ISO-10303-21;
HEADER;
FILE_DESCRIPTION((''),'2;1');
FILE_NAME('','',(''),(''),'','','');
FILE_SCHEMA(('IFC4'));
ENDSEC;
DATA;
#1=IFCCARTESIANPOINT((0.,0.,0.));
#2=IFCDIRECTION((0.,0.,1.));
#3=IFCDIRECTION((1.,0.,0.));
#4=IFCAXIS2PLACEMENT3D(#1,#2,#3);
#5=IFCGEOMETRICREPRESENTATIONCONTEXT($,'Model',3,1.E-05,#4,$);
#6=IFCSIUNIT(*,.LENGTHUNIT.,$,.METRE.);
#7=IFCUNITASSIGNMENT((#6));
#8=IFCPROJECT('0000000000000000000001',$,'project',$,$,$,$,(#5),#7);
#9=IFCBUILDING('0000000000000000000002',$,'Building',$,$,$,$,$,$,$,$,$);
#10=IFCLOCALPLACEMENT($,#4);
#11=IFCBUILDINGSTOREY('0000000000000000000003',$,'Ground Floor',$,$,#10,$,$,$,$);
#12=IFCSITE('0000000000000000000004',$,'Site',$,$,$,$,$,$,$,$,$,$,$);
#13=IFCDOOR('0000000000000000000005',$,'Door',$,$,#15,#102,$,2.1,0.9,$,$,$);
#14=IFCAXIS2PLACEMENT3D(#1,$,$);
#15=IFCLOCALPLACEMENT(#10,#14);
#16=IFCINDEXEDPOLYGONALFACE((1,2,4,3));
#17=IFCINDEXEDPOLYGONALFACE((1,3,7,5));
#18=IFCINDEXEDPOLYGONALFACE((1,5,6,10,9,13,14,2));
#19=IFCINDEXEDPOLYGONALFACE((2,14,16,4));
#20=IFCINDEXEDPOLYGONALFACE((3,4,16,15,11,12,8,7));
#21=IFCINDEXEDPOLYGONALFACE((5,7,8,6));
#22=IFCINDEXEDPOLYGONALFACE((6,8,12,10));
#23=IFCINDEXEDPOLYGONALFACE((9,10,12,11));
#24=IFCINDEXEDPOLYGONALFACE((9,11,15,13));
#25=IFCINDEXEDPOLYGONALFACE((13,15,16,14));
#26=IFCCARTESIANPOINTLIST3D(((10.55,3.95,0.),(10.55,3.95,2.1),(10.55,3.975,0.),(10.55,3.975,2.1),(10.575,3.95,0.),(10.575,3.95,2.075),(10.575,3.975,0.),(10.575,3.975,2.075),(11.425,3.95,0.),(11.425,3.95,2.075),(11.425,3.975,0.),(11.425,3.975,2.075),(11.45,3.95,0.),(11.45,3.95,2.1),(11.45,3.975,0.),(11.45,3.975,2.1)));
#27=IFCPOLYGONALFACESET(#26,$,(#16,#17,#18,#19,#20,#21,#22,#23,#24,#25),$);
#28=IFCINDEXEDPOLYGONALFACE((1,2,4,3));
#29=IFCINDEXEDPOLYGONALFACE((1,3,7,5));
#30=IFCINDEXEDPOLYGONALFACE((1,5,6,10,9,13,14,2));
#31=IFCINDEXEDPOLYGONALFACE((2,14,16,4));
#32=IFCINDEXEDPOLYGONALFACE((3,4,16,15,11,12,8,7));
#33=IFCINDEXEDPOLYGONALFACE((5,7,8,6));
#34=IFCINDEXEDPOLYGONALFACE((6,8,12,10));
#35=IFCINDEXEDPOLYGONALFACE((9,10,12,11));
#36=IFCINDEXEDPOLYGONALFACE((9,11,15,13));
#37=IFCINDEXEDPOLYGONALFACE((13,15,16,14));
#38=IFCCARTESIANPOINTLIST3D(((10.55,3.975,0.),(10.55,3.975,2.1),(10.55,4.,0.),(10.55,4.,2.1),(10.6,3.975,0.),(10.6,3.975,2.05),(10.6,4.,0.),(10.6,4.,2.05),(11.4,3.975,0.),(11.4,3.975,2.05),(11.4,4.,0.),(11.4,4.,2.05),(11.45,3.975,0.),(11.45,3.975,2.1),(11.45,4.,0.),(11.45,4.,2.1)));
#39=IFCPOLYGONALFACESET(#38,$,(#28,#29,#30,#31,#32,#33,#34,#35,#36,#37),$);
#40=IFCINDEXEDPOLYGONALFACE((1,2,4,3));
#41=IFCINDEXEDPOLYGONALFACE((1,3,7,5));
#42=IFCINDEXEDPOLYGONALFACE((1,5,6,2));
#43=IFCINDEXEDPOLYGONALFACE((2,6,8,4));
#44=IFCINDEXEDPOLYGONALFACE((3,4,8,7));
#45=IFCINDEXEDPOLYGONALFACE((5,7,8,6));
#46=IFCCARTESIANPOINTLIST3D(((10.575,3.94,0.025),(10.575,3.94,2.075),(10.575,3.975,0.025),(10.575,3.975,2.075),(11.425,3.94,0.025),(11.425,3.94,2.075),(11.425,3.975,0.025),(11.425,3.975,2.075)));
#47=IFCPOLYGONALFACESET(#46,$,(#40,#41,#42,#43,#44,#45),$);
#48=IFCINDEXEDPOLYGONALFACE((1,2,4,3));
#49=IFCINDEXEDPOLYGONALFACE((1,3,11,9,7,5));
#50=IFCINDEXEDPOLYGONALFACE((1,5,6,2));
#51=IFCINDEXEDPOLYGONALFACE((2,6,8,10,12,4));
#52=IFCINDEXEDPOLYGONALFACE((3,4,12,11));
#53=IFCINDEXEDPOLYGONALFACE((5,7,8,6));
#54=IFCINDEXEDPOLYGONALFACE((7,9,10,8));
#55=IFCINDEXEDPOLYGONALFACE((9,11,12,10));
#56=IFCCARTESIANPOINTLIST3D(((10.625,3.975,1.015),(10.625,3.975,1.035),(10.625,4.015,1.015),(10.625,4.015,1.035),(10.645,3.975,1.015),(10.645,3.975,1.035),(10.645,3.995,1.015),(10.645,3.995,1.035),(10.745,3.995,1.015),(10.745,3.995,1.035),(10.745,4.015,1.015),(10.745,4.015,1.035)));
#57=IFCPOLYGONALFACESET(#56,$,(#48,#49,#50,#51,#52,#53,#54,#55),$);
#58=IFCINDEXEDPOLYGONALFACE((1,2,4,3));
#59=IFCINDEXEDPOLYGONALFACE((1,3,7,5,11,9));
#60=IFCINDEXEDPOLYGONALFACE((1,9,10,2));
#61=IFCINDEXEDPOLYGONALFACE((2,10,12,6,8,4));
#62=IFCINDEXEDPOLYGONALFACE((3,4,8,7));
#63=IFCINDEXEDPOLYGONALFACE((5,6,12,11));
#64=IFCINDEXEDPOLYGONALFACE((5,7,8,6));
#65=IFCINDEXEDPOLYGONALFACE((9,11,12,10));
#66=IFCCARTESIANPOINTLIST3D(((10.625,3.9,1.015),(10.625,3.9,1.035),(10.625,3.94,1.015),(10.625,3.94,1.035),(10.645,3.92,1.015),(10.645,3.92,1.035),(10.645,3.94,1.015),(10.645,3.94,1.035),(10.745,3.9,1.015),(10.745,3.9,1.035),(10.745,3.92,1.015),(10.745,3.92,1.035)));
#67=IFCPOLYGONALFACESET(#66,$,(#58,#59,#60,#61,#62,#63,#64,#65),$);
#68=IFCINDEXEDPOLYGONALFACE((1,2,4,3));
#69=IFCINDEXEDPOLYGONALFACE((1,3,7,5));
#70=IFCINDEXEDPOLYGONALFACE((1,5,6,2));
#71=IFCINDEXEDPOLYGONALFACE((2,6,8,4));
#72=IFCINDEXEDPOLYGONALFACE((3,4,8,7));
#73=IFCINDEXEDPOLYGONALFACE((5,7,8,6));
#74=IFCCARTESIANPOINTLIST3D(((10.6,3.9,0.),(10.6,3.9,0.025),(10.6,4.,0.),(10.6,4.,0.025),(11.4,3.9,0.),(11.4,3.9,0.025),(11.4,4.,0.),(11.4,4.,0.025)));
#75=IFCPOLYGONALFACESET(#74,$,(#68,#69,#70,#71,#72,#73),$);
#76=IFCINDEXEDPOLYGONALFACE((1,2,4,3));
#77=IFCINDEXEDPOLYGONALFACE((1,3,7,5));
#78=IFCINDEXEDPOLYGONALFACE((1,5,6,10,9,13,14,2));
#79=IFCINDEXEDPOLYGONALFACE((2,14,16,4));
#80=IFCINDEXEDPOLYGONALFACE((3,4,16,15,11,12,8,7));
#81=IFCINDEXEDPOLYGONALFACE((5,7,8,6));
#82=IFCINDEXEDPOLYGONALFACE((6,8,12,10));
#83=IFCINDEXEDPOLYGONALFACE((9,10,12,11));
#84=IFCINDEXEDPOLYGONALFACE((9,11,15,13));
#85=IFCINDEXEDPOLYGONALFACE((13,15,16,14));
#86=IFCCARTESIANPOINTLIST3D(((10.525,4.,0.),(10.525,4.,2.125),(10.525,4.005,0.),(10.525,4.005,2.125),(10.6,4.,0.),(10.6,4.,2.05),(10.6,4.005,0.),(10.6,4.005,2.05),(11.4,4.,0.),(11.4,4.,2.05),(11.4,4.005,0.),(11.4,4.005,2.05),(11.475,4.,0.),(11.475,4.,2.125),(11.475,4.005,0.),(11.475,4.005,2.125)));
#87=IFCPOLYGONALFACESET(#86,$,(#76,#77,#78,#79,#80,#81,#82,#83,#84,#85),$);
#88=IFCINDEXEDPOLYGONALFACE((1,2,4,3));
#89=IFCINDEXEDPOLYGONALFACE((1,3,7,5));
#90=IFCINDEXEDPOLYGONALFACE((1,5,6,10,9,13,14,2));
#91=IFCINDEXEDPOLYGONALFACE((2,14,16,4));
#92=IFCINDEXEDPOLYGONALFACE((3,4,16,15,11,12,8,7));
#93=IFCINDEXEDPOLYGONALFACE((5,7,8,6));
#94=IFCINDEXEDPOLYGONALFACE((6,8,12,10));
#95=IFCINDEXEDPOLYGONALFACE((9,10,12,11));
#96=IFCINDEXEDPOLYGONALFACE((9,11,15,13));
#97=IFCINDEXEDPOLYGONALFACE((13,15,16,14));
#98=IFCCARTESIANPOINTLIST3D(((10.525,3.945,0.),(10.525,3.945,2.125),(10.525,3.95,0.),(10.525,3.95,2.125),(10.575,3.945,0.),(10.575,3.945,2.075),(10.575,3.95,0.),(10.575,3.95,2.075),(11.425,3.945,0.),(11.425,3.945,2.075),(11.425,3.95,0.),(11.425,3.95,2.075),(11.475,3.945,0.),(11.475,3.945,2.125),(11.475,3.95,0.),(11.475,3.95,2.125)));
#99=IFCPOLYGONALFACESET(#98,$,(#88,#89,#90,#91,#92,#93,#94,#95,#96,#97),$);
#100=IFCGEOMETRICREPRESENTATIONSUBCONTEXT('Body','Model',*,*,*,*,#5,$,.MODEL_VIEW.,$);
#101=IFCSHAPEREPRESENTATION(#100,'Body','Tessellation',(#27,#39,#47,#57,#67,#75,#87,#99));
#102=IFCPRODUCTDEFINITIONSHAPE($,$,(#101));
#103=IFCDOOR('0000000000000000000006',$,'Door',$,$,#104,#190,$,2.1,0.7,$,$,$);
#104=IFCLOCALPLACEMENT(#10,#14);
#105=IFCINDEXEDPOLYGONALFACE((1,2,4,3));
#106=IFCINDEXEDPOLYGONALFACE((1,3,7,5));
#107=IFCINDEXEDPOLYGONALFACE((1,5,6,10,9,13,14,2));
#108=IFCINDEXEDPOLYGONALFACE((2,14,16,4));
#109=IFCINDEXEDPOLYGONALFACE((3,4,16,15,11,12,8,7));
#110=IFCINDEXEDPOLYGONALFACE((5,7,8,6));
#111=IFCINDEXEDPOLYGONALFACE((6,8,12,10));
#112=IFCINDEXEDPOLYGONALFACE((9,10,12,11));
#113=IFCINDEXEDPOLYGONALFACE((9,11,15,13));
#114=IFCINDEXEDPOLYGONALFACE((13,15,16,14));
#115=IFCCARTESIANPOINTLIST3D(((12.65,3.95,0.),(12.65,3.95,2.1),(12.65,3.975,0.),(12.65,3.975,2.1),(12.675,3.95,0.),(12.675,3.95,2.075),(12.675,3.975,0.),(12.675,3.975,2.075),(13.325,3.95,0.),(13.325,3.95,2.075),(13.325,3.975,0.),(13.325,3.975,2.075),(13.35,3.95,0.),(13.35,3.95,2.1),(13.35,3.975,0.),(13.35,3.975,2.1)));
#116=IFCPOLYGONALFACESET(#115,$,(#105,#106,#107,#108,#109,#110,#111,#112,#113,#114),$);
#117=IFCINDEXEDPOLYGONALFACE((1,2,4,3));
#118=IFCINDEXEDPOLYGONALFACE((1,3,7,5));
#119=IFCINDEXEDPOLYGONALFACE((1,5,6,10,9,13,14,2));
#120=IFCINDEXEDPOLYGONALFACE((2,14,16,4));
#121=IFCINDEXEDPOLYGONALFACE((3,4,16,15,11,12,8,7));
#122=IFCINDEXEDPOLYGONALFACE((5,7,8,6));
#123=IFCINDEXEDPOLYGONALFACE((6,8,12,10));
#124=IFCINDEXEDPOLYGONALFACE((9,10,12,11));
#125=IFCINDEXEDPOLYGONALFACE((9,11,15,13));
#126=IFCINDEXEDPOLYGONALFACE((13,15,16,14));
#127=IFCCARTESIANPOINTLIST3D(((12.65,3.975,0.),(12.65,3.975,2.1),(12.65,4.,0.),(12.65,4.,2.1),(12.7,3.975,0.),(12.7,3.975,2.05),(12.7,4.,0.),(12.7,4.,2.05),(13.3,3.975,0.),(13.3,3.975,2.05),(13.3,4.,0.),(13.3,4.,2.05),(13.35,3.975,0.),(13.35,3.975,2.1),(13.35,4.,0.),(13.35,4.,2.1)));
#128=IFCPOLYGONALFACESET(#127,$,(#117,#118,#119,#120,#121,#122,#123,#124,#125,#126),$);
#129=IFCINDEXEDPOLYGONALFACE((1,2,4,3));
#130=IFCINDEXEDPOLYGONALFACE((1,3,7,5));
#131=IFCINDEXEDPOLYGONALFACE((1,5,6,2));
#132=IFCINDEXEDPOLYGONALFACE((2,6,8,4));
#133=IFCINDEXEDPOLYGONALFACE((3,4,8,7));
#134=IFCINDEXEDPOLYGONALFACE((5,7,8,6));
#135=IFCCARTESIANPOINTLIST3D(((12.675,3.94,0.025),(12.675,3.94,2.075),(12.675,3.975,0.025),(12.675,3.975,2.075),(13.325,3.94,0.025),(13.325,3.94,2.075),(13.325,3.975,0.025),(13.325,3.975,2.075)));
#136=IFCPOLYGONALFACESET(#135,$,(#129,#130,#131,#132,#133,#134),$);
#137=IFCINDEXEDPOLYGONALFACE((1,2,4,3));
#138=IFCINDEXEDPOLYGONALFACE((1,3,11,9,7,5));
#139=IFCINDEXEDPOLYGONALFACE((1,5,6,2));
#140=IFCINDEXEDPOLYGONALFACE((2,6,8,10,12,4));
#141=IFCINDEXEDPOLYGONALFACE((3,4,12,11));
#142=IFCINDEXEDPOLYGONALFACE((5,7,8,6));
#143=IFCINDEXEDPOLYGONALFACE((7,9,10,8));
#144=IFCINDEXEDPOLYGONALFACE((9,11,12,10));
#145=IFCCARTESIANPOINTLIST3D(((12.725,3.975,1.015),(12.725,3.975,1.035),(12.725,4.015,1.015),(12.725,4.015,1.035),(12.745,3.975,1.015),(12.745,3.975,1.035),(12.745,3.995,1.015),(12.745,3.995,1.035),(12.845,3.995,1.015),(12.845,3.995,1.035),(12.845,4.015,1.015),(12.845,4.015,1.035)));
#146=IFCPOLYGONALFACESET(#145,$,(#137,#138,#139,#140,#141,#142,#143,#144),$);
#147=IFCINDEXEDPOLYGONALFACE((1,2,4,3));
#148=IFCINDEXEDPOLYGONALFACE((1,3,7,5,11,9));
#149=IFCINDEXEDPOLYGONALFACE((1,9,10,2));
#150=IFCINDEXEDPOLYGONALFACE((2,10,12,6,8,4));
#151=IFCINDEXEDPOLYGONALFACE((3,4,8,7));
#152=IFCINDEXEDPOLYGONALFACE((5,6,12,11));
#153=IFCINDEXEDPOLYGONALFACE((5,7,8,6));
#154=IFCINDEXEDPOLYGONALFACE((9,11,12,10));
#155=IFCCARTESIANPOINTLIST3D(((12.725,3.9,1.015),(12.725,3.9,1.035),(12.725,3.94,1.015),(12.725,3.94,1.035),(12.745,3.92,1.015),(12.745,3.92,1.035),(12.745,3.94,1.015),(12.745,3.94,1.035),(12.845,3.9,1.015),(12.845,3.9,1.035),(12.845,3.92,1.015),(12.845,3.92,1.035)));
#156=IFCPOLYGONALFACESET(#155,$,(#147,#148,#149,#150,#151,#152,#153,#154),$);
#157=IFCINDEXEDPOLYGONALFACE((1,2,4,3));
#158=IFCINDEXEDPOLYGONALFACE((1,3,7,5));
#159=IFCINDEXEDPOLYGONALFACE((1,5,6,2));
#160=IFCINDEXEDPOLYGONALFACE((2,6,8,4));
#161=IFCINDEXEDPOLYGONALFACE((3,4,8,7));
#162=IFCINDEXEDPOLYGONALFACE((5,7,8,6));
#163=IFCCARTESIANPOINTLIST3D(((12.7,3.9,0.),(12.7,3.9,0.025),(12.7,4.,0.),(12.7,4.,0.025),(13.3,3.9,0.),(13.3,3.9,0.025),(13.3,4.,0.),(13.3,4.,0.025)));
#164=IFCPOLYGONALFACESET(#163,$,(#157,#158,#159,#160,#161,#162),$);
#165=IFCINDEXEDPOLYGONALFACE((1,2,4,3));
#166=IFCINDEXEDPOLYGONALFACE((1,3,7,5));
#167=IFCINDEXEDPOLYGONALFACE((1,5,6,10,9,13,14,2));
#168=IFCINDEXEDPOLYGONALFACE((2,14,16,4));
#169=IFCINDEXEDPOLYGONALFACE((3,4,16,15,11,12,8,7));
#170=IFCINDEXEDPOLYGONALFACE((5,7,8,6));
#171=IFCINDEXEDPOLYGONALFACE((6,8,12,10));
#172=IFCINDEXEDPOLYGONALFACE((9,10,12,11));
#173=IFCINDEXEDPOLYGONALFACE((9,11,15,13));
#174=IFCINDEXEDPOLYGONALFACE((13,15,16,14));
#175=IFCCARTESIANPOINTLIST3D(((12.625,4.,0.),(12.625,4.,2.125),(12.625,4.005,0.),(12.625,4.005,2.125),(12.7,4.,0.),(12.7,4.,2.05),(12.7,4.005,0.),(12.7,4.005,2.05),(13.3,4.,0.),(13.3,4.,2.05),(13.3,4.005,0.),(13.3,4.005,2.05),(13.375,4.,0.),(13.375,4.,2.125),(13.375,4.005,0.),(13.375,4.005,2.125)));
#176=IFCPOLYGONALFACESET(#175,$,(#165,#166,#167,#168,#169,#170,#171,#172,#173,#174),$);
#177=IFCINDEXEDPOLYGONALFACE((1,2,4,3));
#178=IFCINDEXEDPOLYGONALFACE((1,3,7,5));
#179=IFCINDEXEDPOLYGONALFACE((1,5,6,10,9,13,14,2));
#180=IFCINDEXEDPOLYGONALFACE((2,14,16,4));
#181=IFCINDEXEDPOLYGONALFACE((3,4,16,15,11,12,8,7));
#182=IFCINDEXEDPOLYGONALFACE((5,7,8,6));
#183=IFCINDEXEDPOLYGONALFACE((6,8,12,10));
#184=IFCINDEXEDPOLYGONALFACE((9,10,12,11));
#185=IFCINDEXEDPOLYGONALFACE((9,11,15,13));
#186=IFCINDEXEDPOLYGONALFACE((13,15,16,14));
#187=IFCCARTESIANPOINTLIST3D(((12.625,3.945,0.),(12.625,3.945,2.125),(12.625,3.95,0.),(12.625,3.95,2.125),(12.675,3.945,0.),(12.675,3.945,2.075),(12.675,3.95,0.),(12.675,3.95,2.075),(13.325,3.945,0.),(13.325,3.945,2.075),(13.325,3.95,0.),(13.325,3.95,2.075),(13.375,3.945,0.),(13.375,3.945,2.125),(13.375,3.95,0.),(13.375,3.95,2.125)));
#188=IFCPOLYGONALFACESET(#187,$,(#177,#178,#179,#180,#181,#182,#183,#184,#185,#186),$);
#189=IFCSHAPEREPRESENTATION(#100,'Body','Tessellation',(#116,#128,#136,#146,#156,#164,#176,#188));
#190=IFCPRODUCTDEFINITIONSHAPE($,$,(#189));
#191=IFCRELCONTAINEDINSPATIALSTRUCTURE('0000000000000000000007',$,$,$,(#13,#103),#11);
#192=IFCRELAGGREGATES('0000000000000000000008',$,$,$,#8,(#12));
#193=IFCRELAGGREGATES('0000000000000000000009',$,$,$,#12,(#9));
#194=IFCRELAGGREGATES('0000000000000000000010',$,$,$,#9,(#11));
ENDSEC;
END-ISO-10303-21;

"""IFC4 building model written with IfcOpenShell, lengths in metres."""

from ifc_helpers import new_model, si_unit, frame, origin_with_axes, place, context, subcontext, project, spatial, line, indexed_curve, outline, extrude, element, save


model = new_model("IFC4")

# Units and contexts
model_context = context("Model", 3, precision=1e-05, world=origin_with_axes())
body_context = subcontext(model_context, "Body", "Model", "MODEL_VIEW")
ifc_project = project(units=[si_unit("LENGTHUNIT", "METRE")], contexts=[model_context])

# Site, building, storey
site = spatial("IfcSite", under=ifc_project, Name="Site")
building = spatial("IfcBuilding", under=site, Name="Building")
storey_placement = place(None, origin_with_axes())
storey = spatial("IfcBuildingStorey", under=building, at=storey_placement, Name="Ground Floor")

# Doors
door_1_placement = place(storey_placement, frame((11.45, 4.0, 0.0), z_axis=(0.0, 0.0, 1.0), x_axis=(-1.0, 0.0, 0.0)))
element("IfcDoor", 1, at=door_1_placement, inside=storey, Name="Door", OverallHeight=2.1, OverallWidth=0.9, context=body_context, shape_type="SweptSolid", body=[
    extrude(outline(indexed_curve([(0.0, 0.0), (0.0, 2.1), (0.9, 2.1), (0.9, 0.0), (0.875, 0.0), (0.875, 2.075), (0.025, 2.075), (0.025, 0.0)], segments=[line(1, 2, 3, 4, 5, 6, 7, 8, 1)])), frame((0.0, 0.025, 0.0), z_axis=(0.0, -1.0, 0.0), x_axis=(1.0, 0.0, 0.0)), (0.0, 0.0, -1.0), 0.025),
    extrude(outline(indexed_curve([(0.0, 0.0), (0.0, 2.1), (0.9, 2.1), (0.9, 0.0), (0.85, 0.0), (0.85, 2.05), (0.05, 2.05), (0.05, 0.0)], segments=[line(1, 2, 3, 4, 5, 6, 7, 8, 1)])), frame((0.0, 0.0, 0.0), z_axis=(0.0, -1.0, 0.0), x_axis=(1.0, 0.0, 0.0)), (0.0, 0.0, -1.0), 0.025),
    extrude(outline(indexed_curve([(0.0, 0.0), (0.85, 0.0), (0.85, 0.035), (0.0, 0.035)], segments=[line(1, 2, 3, 4, 1)])), frame((0.025, 0.025, 0.025), z_axis=(0.0, 0.0, 1.0), x_axis=(1.0, 0.0, 0.0)), (0.0, 0.0, 1.0), 2.05),
    extrude(outline(indexed_curve([(0.0, 0.0), (0.0, -0.04), (-0.12, -0.04), (-0.12, -0.02), (-0.02, -0.02), (-0.02, 0.0)], segments=[line(1, 2, 3, 4, 5, 6, 1)])), frame((0.825, 0.025, 1.015), z_axis=(0.0, 0.0, 1.0), x_axis=(1.0, 0.0, 0.0)), (0.0, 0.0, 1.0), 0.02),
    extrude(outline(indexed_curve([(0.0, 0.0), (0.0, 0.04), (-0.12, 0.04), (-0.12, 0.02), (-0.02, 0.02), (-0.02, 0.0)], segments=[line(1, 2, 3, 4, 5, 6, 1)])), frame((0.825, 0.06, 1.015), z_axis=(0.0, 0.0, 1.0), x_axis=(1.0, 0.0, 0.0)), (0.0, 0.0, 1.0), 0.02),
    extrude(outline(indexed_curve([(0.0, 0.0), (0.8, 0.0), (0.8, 0.1), (0.0, 0.1)], segments=[line(1, 2, 3, 4, 1)])), frame((0.05, 0.0, 0.0), z_axis=(0.0, 0.0, 1.0), x_axis=(1.0, 0.0, 0.0)), (0.0, 0.0, 1.0), 0.025),
    extrude(outline(indexed_curve([(0.0, 0.0), (0.0, 2.125), (0.95, 2.125), (0.95, 0.0), (0.875, 0.0), (0.875, 2.05), (0.075, 2.05), (0.075, 0.0)], segments=[line(1, 2, 3, 4, 5, 6, 7, 8, 1)])), frame((-0.025, -0.005, 0.0), z_axis=(0.0, -1.0, 0.0), x_axis=(1.0, 0.0, 0.0)), (0.0, 0.0, -1.0), 0.005),
    extrude(outline(indexed_curve([(0.0, 0.0), (0.0, 2.125), (0.95, 2.125), (0.95, 0.0), (0.9, 0.0), (0.9, 2.075), (0.05, 2.075), (0.05, 0.0)], segments=[line(1, 2, 3, 4, 5, 6, 7, 8, 1)])), frame((-0.025, 0.05, 0.0), z_axis=(0.0, -1.0, 0.0), x_axis=(1.0, 0.0, 0.0)), (0.0, 0.0, -1.0), 0.005),
])
door_2_placement = place(storey_placement, frame((13.35, 4.0, 0.0), z_axis=(0.0, 0.0, 1.0), x_axis=(-1.0, 0.0, 0.0)))
element("IfcDoor", 2, at=door_2_placement, inside=storey, Name="Door", OverallHeight=2.1, OverallWidth=0.7, context=body_context, shape_type="SweptSolid", body=[
    extrude(outline(indexed_curve([(0.0, 0.0), (0.0, 2.1), (0.7, 2.1), (0.7, 0.0), (0.675, 0.0), (0.675, 2.075), (0.025, 2.075), (0.025, 0.0)], segments=[line(1, 2, 3, 4, 5, 6, 7, 8, 1)])), frame((0.0, 0.025, 0.0), z_axis=(0.0, -1.0, 0.0), x_axis=(1.0, 0.0, 0.0)), (0.0, 0.0, -1.0), 0.025),
    extrude(outline(indexed_curve([(0.0, 0.0), (0.0, 2.1), (0.7, 2.1), (0.7, 0.0), (0.65, 0.0), (0.65, 2.05), (0.05, 2.05), (0.05, 0.0)], segments=[line(1, 2, 3, 4, 5, 6, 7, 8, 1)])), frame((0.0, 0.0, 0.0), z_axis=(0.0, -1.0, 0.0), x_axis=(1.0, 0.0, 0.0)), (0.0, 0.0, -1.0), 0.025),
    extrude(outline(indexed_curve([(0.0, 0.0), (0.65, 0.0), (0.65, 0.035), (0.0, 0.035)], segments=[line(1, 2, 3, 4, 1)])), frame((0.025, 0.025, 0.025), z_axis=(0.0, 0.0, 1.0), x_axis=(1.0, 0.0, 0.0)), (0.0, 0.0, 1.0), 2.05),
    extrude(outline(indexed_curve([(0.0, 0.0), (0.0, -0.04), (-0.12, -0.04), (-0.12, -0.02), (-0.02, -0.02), (-0.02, 0.0)], segments=[line(1, 2, 3, 4, 5, 6, 1)])), frame((0.625, 0.025, 1.015), z_axis=(0.0, 0.0, 1.0), x_axis=(1.0, 0.0, 0.0)), (0.0, 0.0, 1.0), 0.02),
    extrude(outline(indexed_curve([(0.0, 0.0), (0.0, 0.04), (-0.12, 0.04), (-0.12, 0.02), (-0.02, 0.02), (-0.02, 0.0)], segments=[line(1, 2, 3, 4, 5, 6, 1)])), frame((0.625, 0.06, 1.015), z_axis=(0.0, 0.0, 1.0), x_axis=(1.0, 0.0, 0.0)), (0.0, 0.0, 1.0), 0.02),
    extrude(outline(indexed_curve([(0.0, 0.0), (0.6, 0.0), (0.6, 0.1), (0.0, 0.1)], segments=[line(1, 2, 3, 4, 1)])), frame((0.05, 0.0, 0.0), z_axis=(0.0, 0.0, 1.0), x_axis=(1.0, 0.0, 0.0)), (0.0, 0.0, 1.0), 0.025),
    extrude(outline(indexed_curve([(0.0, 0.0), (0.0, 2.125), (0.75, 2.125), (0.75, 0.0), (0.675, 0.0), (0.675, 2.05), (0.075, 2.05), (0.075, 0.0)], segments=[line(1, 2, 3, 4, 5, 6, 7, 8, 1)])), frame((-0.025, -0.005, 0.0), z_axis=(0.0, -1.0, 0.0), x_axis=(1.0, 0.0, 0.0)), (0.0, 0.0, -1.0), 0.005),
    extrude(outline(indexed_curve([(0.0, 0.0), (0.0, 2.125), (0.75, 2.125), (0.75, 0.0), (0.7, 0.0), (0.7, 2.075), (0.05, 2.075), (0.05, 0.0)], segments=[line(1, 2, 3, 4, 5, 6, 7, 8, 1)])), frame((-0.025, 0.05, 0.0), z_axis=(0.0, -1.0, 0.0), x_axis=(1.0, 0.0, 0.0)), (0.0, 0.0, -1.0), 0.005),
])

save(model, "model.ifc")
